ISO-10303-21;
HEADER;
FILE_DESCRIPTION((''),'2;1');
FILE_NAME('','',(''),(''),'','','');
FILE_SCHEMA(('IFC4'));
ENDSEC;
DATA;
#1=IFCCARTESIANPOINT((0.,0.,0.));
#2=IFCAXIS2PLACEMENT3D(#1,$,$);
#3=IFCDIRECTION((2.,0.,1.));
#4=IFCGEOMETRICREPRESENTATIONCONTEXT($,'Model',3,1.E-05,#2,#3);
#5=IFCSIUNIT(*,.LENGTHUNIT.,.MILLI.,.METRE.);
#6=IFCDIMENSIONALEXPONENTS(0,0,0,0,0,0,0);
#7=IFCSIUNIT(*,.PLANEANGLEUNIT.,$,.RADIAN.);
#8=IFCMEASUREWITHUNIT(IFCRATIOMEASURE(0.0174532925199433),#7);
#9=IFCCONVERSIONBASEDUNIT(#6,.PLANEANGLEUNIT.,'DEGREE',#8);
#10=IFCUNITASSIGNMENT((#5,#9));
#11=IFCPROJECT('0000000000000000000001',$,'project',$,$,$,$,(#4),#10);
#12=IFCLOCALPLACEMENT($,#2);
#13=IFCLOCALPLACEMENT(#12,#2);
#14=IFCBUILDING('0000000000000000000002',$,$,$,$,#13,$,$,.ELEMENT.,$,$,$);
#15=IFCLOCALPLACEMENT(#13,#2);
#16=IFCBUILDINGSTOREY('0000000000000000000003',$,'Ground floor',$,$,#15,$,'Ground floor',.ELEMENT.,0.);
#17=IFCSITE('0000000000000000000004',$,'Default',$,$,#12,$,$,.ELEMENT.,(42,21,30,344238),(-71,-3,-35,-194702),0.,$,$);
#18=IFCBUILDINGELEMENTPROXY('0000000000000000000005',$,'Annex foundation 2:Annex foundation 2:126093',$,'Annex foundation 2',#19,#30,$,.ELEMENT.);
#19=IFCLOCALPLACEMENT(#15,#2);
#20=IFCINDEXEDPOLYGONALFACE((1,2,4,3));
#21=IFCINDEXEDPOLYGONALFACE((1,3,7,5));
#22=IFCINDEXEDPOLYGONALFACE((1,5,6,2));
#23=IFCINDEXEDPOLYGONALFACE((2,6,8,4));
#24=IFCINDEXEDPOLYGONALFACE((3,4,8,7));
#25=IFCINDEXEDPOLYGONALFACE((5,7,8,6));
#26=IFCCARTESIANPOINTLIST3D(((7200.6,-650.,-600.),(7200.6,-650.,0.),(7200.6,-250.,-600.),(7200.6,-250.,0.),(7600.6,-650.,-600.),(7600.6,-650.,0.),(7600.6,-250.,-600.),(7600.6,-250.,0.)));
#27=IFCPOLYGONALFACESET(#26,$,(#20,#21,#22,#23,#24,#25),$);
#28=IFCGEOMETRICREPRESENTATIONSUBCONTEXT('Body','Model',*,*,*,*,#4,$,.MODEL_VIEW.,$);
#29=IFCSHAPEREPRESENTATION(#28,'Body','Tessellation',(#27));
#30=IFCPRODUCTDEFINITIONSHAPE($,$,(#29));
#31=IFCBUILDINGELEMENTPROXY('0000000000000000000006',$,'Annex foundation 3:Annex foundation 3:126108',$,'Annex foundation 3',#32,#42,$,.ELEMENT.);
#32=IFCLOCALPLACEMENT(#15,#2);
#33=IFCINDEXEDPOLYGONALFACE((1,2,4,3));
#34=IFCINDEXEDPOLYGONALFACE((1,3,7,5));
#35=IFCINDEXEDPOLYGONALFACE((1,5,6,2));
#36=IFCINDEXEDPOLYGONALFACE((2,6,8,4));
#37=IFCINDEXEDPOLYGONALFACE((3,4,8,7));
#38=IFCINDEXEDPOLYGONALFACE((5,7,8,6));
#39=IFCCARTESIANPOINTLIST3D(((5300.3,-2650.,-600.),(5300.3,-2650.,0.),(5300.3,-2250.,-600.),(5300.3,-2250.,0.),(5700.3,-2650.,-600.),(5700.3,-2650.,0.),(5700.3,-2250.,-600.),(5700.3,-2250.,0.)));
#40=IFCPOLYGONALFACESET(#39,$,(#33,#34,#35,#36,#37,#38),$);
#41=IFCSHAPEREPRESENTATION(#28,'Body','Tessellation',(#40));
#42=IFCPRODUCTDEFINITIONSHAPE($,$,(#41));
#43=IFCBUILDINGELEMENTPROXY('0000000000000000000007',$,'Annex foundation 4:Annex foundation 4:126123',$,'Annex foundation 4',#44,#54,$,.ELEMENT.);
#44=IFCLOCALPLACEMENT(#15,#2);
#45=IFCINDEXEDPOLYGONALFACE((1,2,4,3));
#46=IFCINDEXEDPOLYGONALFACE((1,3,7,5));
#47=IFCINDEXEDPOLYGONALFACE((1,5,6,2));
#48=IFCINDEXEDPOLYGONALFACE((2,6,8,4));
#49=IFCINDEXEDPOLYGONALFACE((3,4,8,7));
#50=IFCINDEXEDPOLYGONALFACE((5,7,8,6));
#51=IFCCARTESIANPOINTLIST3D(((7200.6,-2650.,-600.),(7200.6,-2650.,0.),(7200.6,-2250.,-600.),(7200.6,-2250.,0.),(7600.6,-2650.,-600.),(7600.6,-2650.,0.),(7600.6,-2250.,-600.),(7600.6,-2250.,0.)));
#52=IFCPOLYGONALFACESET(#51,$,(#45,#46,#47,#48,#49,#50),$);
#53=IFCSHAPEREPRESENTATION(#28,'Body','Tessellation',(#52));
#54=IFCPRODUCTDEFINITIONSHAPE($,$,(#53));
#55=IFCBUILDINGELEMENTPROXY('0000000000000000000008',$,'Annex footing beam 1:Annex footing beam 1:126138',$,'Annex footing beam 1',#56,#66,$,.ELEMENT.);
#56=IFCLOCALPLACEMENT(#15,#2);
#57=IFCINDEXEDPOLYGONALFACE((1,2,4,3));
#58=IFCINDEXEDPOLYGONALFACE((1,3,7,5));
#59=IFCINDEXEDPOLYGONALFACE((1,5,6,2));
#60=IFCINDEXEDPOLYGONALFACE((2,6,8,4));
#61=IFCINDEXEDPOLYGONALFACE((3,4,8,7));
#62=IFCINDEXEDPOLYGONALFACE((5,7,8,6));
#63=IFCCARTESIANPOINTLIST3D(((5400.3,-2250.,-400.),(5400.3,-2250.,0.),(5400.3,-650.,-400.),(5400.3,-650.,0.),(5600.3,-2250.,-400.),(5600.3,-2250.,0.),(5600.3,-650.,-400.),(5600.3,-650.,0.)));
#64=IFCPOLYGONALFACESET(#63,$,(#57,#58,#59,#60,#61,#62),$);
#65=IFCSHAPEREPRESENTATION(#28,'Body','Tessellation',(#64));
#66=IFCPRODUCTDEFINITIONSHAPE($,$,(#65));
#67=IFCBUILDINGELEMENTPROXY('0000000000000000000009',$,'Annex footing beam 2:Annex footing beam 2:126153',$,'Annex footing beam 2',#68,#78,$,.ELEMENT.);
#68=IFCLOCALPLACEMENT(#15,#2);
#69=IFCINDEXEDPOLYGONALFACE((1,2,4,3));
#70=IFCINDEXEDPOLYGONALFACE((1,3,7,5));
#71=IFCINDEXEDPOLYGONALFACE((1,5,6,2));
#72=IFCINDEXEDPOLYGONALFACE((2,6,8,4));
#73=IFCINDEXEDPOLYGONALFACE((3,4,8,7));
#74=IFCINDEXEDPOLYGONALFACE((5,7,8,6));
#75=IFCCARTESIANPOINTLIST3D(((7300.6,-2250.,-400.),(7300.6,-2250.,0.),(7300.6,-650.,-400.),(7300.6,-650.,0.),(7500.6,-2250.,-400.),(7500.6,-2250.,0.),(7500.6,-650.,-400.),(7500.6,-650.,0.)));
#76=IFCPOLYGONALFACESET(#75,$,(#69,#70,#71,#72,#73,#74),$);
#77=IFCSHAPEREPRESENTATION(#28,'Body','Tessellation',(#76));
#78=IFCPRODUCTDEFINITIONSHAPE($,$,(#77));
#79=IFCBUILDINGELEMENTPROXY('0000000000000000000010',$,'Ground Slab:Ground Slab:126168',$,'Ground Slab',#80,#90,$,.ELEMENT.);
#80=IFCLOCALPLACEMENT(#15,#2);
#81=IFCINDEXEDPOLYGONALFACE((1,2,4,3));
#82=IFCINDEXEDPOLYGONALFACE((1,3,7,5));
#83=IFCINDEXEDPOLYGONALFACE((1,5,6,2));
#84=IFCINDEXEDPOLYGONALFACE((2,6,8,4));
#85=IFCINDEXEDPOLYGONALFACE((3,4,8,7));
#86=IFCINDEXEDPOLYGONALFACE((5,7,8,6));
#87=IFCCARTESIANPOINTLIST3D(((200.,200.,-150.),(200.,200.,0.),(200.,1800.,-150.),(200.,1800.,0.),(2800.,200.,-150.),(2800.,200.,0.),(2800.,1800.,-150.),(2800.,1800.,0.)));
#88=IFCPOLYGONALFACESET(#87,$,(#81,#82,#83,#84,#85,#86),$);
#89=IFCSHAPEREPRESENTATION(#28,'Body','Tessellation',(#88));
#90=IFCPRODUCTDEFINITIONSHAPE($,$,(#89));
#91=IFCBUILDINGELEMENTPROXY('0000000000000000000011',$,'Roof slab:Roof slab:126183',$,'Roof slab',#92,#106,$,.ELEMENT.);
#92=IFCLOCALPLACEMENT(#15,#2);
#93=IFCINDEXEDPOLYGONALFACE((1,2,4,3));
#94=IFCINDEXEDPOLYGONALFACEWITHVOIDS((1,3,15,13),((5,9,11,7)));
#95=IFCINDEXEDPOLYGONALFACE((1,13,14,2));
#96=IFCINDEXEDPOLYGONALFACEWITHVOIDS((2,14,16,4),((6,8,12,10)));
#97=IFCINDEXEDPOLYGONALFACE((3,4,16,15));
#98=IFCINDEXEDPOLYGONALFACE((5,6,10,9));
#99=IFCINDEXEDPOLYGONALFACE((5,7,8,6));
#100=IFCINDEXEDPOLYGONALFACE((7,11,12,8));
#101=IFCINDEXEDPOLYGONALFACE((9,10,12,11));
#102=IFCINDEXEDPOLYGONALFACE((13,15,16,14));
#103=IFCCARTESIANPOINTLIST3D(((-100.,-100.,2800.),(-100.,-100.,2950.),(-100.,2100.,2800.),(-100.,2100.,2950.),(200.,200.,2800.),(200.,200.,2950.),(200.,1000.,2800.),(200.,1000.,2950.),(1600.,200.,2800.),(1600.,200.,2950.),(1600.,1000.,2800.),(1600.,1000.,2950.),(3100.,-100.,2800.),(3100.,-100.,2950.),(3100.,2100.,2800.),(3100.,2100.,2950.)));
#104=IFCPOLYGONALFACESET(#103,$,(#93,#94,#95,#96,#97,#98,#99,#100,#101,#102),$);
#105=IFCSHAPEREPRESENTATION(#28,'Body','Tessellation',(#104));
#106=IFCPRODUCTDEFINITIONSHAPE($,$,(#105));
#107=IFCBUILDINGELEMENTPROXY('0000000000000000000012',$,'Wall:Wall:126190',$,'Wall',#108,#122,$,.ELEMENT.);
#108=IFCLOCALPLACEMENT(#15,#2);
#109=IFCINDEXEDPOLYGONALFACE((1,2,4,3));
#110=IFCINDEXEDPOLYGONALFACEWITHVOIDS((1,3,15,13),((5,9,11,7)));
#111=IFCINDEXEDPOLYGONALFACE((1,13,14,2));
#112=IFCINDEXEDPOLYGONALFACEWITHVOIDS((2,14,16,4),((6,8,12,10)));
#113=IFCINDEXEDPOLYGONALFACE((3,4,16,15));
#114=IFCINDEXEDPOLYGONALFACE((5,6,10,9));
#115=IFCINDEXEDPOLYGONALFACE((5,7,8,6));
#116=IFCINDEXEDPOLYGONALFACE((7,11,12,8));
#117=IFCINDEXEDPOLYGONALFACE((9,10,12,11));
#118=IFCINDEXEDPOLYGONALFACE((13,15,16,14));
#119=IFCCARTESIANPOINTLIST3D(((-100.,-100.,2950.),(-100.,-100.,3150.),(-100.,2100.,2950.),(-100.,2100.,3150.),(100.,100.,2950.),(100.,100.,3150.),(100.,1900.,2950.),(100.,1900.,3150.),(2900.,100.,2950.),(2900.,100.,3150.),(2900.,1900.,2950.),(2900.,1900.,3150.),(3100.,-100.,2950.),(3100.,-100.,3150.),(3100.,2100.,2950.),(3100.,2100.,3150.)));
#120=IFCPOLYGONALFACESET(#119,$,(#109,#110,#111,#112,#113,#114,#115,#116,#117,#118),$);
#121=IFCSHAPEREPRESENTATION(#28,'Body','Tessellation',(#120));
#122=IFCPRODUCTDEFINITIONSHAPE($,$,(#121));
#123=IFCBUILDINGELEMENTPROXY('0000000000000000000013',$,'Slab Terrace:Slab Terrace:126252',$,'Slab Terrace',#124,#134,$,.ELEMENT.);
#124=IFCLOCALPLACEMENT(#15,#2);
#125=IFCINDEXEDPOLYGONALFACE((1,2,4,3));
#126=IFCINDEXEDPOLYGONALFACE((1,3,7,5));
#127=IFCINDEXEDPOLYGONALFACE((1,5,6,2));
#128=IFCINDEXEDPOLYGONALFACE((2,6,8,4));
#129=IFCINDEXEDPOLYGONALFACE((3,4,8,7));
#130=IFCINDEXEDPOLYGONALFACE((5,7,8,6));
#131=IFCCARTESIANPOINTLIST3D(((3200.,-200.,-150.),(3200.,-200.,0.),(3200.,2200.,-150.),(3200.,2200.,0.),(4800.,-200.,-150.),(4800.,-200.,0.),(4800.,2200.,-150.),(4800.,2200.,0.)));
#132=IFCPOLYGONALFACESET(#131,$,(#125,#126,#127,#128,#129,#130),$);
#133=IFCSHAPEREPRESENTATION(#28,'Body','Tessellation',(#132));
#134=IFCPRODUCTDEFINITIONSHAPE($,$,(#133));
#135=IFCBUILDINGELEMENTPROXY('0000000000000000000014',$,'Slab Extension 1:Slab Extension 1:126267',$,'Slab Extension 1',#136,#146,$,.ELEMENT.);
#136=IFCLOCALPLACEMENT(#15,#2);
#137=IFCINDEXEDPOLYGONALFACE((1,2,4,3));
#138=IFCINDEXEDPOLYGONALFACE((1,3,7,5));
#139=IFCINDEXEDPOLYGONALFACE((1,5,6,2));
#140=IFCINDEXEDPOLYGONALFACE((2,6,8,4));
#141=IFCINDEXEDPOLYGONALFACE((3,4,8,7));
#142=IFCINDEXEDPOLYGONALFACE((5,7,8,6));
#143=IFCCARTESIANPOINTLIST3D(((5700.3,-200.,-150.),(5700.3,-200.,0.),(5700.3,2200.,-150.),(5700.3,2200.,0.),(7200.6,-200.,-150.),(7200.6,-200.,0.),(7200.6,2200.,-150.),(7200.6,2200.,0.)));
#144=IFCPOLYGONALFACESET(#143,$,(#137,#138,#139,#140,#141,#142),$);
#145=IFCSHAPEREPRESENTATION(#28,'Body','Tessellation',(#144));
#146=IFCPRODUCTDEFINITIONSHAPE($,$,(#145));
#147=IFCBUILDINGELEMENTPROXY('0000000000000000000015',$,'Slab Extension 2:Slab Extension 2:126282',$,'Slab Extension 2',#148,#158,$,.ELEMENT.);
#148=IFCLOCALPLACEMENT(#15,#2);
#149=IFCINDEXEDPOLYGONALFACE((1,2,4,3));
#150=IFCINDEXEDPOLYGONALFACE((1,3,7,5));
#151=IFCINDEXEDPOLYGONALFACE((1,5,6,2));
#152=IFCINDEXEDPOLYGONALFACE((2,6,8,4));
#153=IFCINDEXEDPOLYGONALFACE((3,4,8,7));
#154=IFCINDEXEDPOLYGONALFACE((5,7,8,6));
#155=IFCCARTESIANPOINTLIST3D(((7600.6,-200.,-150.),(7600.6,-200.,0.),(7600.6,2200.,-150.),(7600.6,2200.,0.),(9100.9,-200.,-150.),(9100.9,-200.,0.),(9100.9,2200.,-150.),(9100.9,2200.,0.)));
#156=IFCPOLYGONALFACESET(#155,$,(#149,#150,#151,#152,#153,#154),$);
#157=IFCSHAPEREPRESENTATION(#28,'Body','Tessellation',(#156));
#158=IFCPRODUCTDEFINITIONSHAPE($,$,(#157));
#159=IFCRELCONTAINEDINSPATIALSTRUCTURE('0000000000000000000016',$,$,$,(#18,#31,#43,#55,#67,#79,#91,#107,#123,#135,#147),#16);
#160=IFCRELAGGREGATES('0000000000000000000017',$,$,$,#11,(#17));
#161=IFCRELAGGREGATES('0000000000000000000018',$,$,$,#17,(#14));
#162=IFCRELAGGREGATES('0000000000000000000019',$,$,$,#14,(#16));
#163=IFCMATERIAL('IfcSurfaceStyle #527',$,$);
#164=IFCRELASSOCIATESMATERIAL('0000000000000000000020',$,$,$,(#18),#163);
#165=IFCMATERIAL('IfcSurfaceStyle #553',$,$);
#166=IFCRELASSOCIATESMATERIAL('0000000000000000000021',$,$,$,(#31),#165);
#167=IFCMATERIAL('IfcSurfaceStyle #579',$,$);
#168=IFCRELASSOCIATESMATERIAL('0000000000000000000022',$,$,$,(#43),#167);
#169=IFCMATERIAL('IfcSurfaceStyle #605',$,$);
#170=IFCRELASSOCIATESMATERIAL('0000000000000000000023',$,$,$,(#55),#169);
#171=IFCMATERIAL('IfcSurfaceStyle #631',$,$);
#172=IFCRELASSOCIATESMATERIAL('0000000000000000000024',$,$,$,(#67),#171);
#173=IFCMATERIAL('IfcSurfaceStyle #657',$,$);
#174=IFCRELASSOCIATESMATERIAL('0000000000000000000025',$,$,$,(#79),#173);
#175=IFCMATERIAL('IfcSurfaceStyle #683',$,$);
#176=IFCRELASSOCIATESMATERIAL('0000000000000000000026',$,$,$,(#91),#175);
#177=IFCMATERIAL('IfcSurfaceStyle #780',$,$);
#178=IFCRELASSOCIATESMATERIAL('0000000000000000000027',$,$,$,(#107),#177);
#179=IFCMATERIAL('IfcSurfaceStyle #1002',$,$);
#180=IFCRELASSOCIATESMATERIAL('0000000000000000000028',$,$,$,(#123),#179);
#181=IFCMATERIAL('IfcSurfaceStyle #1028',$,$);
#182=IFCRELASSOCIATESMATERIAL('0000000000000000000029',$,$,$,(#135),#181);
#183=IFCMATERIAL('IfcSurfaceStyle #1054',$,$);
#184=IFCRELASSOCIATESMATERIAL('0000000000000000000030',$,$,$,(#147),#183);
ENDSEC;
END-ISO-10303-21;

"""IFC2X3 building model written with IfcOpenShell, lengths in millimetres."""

from ifc_helpers import new_model, entity, si_unit, converted_unit, direction, frame, frame_2d, origin, origin_2d_with_axis, place, context, subcontext, project, spatial, polyline, rectangle, outline, extrude, source, transform, mapped, material, element, save


model = new_model("IFC2X3")

# Units and contexts
model_context = context("Model", 3, precision=1e-05, world=origin(), true_north=direction((2.0, 0.0, 1.0)))
body_context = subcontext(model_context, "Body", "Model", "MODEL_VIEW")
ifc_project = project(units=[si_unit("LENGTHUNIT", "METRE", prefix="MILLI"), converted_unit("PLANEANGLEUNIT", "DEGREE", entity("IfcRatioMeasure", 0.0174532925199433), si_unit("PLANEANGLEUNIT", "RADIAN"), dimensions=[0, 0, 0, 0, 0, 0, 0])], contexts=[model_context])

# Site, building, storey
site_placement = place(None, origin())
site = spatial("IfcSite", under=ifc_project, at=site_placement, Name="Default", CompositionType="ELEMENT", RefLatitude=(42, 21, 30, 344238), RefLongitude=(-71, -3, -35, -194702), RefElevation=0.0)
building_placement = place(site_placement, origin())
building = spatial("IfcBuilding", under=site, at=building_placement, CompositionType="ELEMENT")
storey_placement = place(building_placement, origin())
storey = spatial("IfcBuildingStorey", under=building, at=storey_placement, Name="Ground floor", LongName="Ground floor", CompositionType="ELEMENT", Elevation=0.0)

# Building element proxies
ifc_material_1 = material(Name="IfcSurfaceStyle #527")
shared_shape_1 = source(origin(), body_context, "Body", "SweptSolid", [
    extrude(rectangle(XDim=400.0, YDim=400.0, at=origin_2d_with_axis()), frame((7400.6, -450.0, -600.0), z_axis=(0.0, 0.0, 1.0), x_axis=(0.0, 1.0, 0.0)), (0.0, 0.0, 1.0), 600.0),
])
proxy_1_placement = place(storey_placement, origin())
element("IfcBuildingElementProxy", 1, at=proxy_1_placement, inside=storey, material=ifc_material_1, Name="Annex foundation 2:Annex foundation 2:126093", ObjectType="Annex foundation 2", CompositionType="ELEMENT", context=body_context, shape_type="MappedRepresentation", body=[
    mapped(shared_shape_1, transform((0.0, 0.0, 0.0), scale=1.0)),
])
ifc_material_2 = material(Name="IfcSurfaceStyle #553")
shared_shape_2 = source(origin(), body_context, "Body", "SweptSolid", [
    extrude(rectangle(XDim=400.0, YDim=400.0, at=origin_2d_with_axis()), frame((5500.3, -2450.0, -600.0), z_axis=(0.0, 0.0, 1.0), x_axis=(0.0, 1.0, 0.0)), (0.0, 0.0, 1.0), 600.0),
])
proxy_2_placement = place(storey_placement, origin())
element("IfcBuildingElementProxy", 2, at=proxy_2_placement, inside=storey, material=ifc_material_2, Name="Annex foundation 3:Annex foundation 3:126108", ObjectType="Annex foundation 3", CompositionType="ELEMENT", context=body_context, shape_type="MappedRepresentation", body=[
    mapped(shared_shape_2, transform((0.0, 0.0, 0.0), scale=1.0)),
])
ifc_material_3 = material(Name="IfcSurfaceStyle #579")
shared_shape_3 = source(origin(), body_context, "Body", "SweptSolid", [
    extrude(rectangle(XDim=400.0, YDim=400.0, at=origin_2d_with_axis()), frame((7400.6, -2450.0, -600.0), z_axis=(0.0, 0.0, 1.0), x_axis=(0.0, 1.0, 0.0)), (0.0, 0.0, 1.0), 600.0),
])
proxy_3_placement = place(storey_placement, origin())
element("IfcBuildingElementProxy", 3, at=proxy_3_placement, inside=storey, material=ifc_material_3, Name="Annex foundation 4:Annex foundation 4:126123", ObjectType="Annex foundation 4", CompositionType="ELEMENT", context=body_context, shape_type="MappedRepresentation", body=[
    mapped(shared_shape_3, transform((0.0, 0.0, 0.0), scale=1.0)),
])
ifc_material_4 = material(Name="IfcSurfaceStyle #605")
shared_shape_4 = source(origin(), body_context, "Body", "SweptSolid", [
    extrude(rectangle(XDim=1600.0, YDim=200.0, at=origin_2d_with_axis()), frame((5500.3, -1450.0, -400.0), z_axis=(0.0, 0.0, 1.0), x_axis=(0.0, -1.0, 0.0)), (0.0, 0.0, 1.0), 400.0),
])
proxy_4_placement = place(storey_placement, origin())
element("IfcBuildingElementProxy", 4, at=proxy_4_placement, inside=storey, material=ifc_material_4, Name="Annex footing beam 1:Annex footing beam 1:126138", ObjectType="Annex footing beam 1", CompositionType="ELEMENT", context=body_context, shape_type="MappedRepresentation", body=[
    mapped(shared_shape_4, transform((0.0, 0.0, 0.0), scale=1.0)),
])
ifc_material_5 = material(Name="IfcSurfaceStyle #631")
shared_shape_5 = source(origin(), body_context, "Body", "SweptSolid", [
    extrude(rectangle(XDim=1600.0, YDim=200.0, at=origin_2d_with_axis()), frame((7400.6, -1450.0, -400.0), z_axis=(0.0, 0.0, 1.0), x_axis=(0.0, -1.0, 0.0)), (0.0, 0.0, 1.0), 400.0),
])
proxy_5_placement = place(storey_placement, origin())
element("IfcBuildingElementProxy", 5, at=proxy_5_placement, inside=storey, material=ifc_material_5, Name="Annex footing beam 2:Annex footing beam 2:126153", ObjectType="Annex footing beam 2", CompositionType="ELEMENT", context=body_context, shape_type="MappedRepresentation", body=[
    mapped(shared_shape_5, transform((0.0, 0.0, 0.0), scale=1.0)),
])
ifc_material_6 = material(Name="IfcSurfaceStyle #657")
shared_shape_6 = source(origin(), body_context, "Body", "SweptSolid", [
    extrude(rectangle(XDim=2600.0, YDim=1600.0, at=origin_2d_with_axis()), frame((1500.0, 1000.0, -150.0)), (0.0, 0.0, 1.0), 150.0),
])
proxy_6_placement = place(storey_placement, origin())
element("IfcBuildingElementProxy", 6, at=proxy_6_placement, inside=storey, material=ifc_material_6, Name="Ground Slab:Ground Slab:126168", ObjectType="Ground Slab", CompositionType="ELEMENT", context=body_context, shape_type="MappedRepresentation", body=[
    mapped(shared_shape_6, transform((0.0, 0.0, 0.0), scale=1.0)),
])
ifc_material_7 = material(Name="IfcSurfaceStyle #683")
shared_shape_7 = source(origin(), body_context, "Body", "SweptSolid", [
    extrude(outline(polyline([(-1600.0, -1100.0), (1600.0, -1100.0), (1600.0, 1100.0), (-1600.0, 1100.0), (-1600.0, -1100.0)]), holes=[polyline([(100.0, 0.0), (100.0, -800.0), (-1300.0, -800.0), (-1300.0, 0.0), (100.0, 0.0)])]), frame((1500.0, 1000.0, 2800.0)), (0.0, 0.0, 1.0), 150.0),
])
proxy_7_placement = place(storey_placement, origin())
element("IfcBuildingElementProxy", 7, at=proxy_7_placement, inside=storey, material=ifc_material_7, Name="Roof slab:Roof slab:126183", ObjectType="Roof slab", CompositionType="ELEMENT", context=body_context, shape_type="MappedRepresentation", body=[
    mapped(shared_shape_7, transform((0.0, 0.0, 0.0), scale=1.0)),
])
ifc_material_8 = material(Name="IfcSurfaceStyle #780")
shared_shape_8 = source(origin(), body_context, "Body", "SweptSolid", [
    extrude(outline(polyline([(-1600.0, -1100.0), (1600.0, -1100.0), (1600.0, 1100.0), (-1600.0, 1100.0), (-1600.0, -1100.0)]), holes=[polyline([(-1400.0, 900.0), (1400.0, 900.0), (1400.0, -900.0), (-1400.0, -900.0), (-1400.0, 900.0)])]), frame((1500.0, 1000.0, 2950.0), z_axis=(0.0, 0.0, 1.0), x_axis=(-1.0, 0.0, 0.0)), (0.0, 0.0, 1.0), 200.0),
])
proxy_8_placement = place(storey_placement, origin())
element("IfcBuildingElementProxy", 8, at=proxy_8_placement, inside=storey, material=ifc_material_8, Name="Wall:Wall:126190", ObjectType="Wall", CompositionType="ELEMENT", context=body_context, shape_type="MappedRepresentation", body=[
    mapped(shared_shape_8, transform((0.0, 0.0, 0.0), scale=1.0)),
])
ifc_material_9 = material(Name="IfcSurfaceStyle #1002")
shared_shape_9 = source(origin(), body_context, "Body", "SweptSolid", [
    extrude(rectangle(XDim=1600.0, YDim=2400.0, at=origin_2d_with_axis()), frame((4000.0, 1000.0, -150.0), z_axis=(0.0, 0.0, 1.0), x_axis=(-1.0, 0.0, 0.0)), (0.0, 0.0, 1.0), 150.0),
])
proxy_9_placement = place(storey_placement, origin())
element("IfcBuildingElementProxy", 9, at=proxy_9_placement, inside=storey, material=ifc_material_9, Name="Slab Terrace:Slab Terrace:126252", ObjectType="Slab Terrace", CompositionType="ELEMENT", context=body_context, shape_type="MappedRepresentation", body=[
    mapped(shared_shape_9, transform((0.0, 0.0, 0.0), scale=1.0)),
])
ifc_material_10 = material(Name="IfcSurfaceStyle #1028")
shared_shape_10 = source(origin(), body_context, "Body", "SweptSolid", [
    extrude(rectangle(XDim=1500.3, YDim=2400.0, at=frame_2d((0.0, 0.0), x_axis=(1.0, 0.0))), frame((6450.4, 1000.0, -150.0)), (0.0, 0.0, 1.0), 150.0),
])
proxy_10_placement = place(storey_placement, origin())
element("IfcBuildingElementProxy", 10, at=proxy_10_placement, inside=storey, material=ifc_material_10, Name="Slab Extension 1:Slab Extension 1:126267", ObjectType="Slab Extension 1", CompositionType="ELEMENT", context=body_context, shape_type="MappedRepresentation", body=[
    mapped(shared_shape_10, transform((0.0, 0.0, 0.0), scale=1.0)),
])
ifc_material_11 = material(Name="IfcSurfaceStyle #1054")
shared_shape_11 = source(origin(), body_context, "Body", "SweptSolid", [
    extrude(rectangle(XDim=1500.3, YDim=2400.0, at=origin_2d_with_axis()), frame((8350.8, 1000.0, -150.0)), (0.0, 0.0, 1.0), 150.0),
])
proxy_11_placement = place(storey_placement, origin())
element("IfcBuildingElementProxy", 11, at=proxy_11_placement, inside=storey, material=ifc_material_11, Name="Slab Extension 2:Slab Extension 2:126282", ObjectType="Slab Extension 2", CompositionType="ELEMENT", context=body_context, shape_type="MappedRepresentation", body=[
    mapped(shared_shape_11, transform((0.0, 0.0, 0.0), scale=1.0)),
])

save(model, "model.ifc")
